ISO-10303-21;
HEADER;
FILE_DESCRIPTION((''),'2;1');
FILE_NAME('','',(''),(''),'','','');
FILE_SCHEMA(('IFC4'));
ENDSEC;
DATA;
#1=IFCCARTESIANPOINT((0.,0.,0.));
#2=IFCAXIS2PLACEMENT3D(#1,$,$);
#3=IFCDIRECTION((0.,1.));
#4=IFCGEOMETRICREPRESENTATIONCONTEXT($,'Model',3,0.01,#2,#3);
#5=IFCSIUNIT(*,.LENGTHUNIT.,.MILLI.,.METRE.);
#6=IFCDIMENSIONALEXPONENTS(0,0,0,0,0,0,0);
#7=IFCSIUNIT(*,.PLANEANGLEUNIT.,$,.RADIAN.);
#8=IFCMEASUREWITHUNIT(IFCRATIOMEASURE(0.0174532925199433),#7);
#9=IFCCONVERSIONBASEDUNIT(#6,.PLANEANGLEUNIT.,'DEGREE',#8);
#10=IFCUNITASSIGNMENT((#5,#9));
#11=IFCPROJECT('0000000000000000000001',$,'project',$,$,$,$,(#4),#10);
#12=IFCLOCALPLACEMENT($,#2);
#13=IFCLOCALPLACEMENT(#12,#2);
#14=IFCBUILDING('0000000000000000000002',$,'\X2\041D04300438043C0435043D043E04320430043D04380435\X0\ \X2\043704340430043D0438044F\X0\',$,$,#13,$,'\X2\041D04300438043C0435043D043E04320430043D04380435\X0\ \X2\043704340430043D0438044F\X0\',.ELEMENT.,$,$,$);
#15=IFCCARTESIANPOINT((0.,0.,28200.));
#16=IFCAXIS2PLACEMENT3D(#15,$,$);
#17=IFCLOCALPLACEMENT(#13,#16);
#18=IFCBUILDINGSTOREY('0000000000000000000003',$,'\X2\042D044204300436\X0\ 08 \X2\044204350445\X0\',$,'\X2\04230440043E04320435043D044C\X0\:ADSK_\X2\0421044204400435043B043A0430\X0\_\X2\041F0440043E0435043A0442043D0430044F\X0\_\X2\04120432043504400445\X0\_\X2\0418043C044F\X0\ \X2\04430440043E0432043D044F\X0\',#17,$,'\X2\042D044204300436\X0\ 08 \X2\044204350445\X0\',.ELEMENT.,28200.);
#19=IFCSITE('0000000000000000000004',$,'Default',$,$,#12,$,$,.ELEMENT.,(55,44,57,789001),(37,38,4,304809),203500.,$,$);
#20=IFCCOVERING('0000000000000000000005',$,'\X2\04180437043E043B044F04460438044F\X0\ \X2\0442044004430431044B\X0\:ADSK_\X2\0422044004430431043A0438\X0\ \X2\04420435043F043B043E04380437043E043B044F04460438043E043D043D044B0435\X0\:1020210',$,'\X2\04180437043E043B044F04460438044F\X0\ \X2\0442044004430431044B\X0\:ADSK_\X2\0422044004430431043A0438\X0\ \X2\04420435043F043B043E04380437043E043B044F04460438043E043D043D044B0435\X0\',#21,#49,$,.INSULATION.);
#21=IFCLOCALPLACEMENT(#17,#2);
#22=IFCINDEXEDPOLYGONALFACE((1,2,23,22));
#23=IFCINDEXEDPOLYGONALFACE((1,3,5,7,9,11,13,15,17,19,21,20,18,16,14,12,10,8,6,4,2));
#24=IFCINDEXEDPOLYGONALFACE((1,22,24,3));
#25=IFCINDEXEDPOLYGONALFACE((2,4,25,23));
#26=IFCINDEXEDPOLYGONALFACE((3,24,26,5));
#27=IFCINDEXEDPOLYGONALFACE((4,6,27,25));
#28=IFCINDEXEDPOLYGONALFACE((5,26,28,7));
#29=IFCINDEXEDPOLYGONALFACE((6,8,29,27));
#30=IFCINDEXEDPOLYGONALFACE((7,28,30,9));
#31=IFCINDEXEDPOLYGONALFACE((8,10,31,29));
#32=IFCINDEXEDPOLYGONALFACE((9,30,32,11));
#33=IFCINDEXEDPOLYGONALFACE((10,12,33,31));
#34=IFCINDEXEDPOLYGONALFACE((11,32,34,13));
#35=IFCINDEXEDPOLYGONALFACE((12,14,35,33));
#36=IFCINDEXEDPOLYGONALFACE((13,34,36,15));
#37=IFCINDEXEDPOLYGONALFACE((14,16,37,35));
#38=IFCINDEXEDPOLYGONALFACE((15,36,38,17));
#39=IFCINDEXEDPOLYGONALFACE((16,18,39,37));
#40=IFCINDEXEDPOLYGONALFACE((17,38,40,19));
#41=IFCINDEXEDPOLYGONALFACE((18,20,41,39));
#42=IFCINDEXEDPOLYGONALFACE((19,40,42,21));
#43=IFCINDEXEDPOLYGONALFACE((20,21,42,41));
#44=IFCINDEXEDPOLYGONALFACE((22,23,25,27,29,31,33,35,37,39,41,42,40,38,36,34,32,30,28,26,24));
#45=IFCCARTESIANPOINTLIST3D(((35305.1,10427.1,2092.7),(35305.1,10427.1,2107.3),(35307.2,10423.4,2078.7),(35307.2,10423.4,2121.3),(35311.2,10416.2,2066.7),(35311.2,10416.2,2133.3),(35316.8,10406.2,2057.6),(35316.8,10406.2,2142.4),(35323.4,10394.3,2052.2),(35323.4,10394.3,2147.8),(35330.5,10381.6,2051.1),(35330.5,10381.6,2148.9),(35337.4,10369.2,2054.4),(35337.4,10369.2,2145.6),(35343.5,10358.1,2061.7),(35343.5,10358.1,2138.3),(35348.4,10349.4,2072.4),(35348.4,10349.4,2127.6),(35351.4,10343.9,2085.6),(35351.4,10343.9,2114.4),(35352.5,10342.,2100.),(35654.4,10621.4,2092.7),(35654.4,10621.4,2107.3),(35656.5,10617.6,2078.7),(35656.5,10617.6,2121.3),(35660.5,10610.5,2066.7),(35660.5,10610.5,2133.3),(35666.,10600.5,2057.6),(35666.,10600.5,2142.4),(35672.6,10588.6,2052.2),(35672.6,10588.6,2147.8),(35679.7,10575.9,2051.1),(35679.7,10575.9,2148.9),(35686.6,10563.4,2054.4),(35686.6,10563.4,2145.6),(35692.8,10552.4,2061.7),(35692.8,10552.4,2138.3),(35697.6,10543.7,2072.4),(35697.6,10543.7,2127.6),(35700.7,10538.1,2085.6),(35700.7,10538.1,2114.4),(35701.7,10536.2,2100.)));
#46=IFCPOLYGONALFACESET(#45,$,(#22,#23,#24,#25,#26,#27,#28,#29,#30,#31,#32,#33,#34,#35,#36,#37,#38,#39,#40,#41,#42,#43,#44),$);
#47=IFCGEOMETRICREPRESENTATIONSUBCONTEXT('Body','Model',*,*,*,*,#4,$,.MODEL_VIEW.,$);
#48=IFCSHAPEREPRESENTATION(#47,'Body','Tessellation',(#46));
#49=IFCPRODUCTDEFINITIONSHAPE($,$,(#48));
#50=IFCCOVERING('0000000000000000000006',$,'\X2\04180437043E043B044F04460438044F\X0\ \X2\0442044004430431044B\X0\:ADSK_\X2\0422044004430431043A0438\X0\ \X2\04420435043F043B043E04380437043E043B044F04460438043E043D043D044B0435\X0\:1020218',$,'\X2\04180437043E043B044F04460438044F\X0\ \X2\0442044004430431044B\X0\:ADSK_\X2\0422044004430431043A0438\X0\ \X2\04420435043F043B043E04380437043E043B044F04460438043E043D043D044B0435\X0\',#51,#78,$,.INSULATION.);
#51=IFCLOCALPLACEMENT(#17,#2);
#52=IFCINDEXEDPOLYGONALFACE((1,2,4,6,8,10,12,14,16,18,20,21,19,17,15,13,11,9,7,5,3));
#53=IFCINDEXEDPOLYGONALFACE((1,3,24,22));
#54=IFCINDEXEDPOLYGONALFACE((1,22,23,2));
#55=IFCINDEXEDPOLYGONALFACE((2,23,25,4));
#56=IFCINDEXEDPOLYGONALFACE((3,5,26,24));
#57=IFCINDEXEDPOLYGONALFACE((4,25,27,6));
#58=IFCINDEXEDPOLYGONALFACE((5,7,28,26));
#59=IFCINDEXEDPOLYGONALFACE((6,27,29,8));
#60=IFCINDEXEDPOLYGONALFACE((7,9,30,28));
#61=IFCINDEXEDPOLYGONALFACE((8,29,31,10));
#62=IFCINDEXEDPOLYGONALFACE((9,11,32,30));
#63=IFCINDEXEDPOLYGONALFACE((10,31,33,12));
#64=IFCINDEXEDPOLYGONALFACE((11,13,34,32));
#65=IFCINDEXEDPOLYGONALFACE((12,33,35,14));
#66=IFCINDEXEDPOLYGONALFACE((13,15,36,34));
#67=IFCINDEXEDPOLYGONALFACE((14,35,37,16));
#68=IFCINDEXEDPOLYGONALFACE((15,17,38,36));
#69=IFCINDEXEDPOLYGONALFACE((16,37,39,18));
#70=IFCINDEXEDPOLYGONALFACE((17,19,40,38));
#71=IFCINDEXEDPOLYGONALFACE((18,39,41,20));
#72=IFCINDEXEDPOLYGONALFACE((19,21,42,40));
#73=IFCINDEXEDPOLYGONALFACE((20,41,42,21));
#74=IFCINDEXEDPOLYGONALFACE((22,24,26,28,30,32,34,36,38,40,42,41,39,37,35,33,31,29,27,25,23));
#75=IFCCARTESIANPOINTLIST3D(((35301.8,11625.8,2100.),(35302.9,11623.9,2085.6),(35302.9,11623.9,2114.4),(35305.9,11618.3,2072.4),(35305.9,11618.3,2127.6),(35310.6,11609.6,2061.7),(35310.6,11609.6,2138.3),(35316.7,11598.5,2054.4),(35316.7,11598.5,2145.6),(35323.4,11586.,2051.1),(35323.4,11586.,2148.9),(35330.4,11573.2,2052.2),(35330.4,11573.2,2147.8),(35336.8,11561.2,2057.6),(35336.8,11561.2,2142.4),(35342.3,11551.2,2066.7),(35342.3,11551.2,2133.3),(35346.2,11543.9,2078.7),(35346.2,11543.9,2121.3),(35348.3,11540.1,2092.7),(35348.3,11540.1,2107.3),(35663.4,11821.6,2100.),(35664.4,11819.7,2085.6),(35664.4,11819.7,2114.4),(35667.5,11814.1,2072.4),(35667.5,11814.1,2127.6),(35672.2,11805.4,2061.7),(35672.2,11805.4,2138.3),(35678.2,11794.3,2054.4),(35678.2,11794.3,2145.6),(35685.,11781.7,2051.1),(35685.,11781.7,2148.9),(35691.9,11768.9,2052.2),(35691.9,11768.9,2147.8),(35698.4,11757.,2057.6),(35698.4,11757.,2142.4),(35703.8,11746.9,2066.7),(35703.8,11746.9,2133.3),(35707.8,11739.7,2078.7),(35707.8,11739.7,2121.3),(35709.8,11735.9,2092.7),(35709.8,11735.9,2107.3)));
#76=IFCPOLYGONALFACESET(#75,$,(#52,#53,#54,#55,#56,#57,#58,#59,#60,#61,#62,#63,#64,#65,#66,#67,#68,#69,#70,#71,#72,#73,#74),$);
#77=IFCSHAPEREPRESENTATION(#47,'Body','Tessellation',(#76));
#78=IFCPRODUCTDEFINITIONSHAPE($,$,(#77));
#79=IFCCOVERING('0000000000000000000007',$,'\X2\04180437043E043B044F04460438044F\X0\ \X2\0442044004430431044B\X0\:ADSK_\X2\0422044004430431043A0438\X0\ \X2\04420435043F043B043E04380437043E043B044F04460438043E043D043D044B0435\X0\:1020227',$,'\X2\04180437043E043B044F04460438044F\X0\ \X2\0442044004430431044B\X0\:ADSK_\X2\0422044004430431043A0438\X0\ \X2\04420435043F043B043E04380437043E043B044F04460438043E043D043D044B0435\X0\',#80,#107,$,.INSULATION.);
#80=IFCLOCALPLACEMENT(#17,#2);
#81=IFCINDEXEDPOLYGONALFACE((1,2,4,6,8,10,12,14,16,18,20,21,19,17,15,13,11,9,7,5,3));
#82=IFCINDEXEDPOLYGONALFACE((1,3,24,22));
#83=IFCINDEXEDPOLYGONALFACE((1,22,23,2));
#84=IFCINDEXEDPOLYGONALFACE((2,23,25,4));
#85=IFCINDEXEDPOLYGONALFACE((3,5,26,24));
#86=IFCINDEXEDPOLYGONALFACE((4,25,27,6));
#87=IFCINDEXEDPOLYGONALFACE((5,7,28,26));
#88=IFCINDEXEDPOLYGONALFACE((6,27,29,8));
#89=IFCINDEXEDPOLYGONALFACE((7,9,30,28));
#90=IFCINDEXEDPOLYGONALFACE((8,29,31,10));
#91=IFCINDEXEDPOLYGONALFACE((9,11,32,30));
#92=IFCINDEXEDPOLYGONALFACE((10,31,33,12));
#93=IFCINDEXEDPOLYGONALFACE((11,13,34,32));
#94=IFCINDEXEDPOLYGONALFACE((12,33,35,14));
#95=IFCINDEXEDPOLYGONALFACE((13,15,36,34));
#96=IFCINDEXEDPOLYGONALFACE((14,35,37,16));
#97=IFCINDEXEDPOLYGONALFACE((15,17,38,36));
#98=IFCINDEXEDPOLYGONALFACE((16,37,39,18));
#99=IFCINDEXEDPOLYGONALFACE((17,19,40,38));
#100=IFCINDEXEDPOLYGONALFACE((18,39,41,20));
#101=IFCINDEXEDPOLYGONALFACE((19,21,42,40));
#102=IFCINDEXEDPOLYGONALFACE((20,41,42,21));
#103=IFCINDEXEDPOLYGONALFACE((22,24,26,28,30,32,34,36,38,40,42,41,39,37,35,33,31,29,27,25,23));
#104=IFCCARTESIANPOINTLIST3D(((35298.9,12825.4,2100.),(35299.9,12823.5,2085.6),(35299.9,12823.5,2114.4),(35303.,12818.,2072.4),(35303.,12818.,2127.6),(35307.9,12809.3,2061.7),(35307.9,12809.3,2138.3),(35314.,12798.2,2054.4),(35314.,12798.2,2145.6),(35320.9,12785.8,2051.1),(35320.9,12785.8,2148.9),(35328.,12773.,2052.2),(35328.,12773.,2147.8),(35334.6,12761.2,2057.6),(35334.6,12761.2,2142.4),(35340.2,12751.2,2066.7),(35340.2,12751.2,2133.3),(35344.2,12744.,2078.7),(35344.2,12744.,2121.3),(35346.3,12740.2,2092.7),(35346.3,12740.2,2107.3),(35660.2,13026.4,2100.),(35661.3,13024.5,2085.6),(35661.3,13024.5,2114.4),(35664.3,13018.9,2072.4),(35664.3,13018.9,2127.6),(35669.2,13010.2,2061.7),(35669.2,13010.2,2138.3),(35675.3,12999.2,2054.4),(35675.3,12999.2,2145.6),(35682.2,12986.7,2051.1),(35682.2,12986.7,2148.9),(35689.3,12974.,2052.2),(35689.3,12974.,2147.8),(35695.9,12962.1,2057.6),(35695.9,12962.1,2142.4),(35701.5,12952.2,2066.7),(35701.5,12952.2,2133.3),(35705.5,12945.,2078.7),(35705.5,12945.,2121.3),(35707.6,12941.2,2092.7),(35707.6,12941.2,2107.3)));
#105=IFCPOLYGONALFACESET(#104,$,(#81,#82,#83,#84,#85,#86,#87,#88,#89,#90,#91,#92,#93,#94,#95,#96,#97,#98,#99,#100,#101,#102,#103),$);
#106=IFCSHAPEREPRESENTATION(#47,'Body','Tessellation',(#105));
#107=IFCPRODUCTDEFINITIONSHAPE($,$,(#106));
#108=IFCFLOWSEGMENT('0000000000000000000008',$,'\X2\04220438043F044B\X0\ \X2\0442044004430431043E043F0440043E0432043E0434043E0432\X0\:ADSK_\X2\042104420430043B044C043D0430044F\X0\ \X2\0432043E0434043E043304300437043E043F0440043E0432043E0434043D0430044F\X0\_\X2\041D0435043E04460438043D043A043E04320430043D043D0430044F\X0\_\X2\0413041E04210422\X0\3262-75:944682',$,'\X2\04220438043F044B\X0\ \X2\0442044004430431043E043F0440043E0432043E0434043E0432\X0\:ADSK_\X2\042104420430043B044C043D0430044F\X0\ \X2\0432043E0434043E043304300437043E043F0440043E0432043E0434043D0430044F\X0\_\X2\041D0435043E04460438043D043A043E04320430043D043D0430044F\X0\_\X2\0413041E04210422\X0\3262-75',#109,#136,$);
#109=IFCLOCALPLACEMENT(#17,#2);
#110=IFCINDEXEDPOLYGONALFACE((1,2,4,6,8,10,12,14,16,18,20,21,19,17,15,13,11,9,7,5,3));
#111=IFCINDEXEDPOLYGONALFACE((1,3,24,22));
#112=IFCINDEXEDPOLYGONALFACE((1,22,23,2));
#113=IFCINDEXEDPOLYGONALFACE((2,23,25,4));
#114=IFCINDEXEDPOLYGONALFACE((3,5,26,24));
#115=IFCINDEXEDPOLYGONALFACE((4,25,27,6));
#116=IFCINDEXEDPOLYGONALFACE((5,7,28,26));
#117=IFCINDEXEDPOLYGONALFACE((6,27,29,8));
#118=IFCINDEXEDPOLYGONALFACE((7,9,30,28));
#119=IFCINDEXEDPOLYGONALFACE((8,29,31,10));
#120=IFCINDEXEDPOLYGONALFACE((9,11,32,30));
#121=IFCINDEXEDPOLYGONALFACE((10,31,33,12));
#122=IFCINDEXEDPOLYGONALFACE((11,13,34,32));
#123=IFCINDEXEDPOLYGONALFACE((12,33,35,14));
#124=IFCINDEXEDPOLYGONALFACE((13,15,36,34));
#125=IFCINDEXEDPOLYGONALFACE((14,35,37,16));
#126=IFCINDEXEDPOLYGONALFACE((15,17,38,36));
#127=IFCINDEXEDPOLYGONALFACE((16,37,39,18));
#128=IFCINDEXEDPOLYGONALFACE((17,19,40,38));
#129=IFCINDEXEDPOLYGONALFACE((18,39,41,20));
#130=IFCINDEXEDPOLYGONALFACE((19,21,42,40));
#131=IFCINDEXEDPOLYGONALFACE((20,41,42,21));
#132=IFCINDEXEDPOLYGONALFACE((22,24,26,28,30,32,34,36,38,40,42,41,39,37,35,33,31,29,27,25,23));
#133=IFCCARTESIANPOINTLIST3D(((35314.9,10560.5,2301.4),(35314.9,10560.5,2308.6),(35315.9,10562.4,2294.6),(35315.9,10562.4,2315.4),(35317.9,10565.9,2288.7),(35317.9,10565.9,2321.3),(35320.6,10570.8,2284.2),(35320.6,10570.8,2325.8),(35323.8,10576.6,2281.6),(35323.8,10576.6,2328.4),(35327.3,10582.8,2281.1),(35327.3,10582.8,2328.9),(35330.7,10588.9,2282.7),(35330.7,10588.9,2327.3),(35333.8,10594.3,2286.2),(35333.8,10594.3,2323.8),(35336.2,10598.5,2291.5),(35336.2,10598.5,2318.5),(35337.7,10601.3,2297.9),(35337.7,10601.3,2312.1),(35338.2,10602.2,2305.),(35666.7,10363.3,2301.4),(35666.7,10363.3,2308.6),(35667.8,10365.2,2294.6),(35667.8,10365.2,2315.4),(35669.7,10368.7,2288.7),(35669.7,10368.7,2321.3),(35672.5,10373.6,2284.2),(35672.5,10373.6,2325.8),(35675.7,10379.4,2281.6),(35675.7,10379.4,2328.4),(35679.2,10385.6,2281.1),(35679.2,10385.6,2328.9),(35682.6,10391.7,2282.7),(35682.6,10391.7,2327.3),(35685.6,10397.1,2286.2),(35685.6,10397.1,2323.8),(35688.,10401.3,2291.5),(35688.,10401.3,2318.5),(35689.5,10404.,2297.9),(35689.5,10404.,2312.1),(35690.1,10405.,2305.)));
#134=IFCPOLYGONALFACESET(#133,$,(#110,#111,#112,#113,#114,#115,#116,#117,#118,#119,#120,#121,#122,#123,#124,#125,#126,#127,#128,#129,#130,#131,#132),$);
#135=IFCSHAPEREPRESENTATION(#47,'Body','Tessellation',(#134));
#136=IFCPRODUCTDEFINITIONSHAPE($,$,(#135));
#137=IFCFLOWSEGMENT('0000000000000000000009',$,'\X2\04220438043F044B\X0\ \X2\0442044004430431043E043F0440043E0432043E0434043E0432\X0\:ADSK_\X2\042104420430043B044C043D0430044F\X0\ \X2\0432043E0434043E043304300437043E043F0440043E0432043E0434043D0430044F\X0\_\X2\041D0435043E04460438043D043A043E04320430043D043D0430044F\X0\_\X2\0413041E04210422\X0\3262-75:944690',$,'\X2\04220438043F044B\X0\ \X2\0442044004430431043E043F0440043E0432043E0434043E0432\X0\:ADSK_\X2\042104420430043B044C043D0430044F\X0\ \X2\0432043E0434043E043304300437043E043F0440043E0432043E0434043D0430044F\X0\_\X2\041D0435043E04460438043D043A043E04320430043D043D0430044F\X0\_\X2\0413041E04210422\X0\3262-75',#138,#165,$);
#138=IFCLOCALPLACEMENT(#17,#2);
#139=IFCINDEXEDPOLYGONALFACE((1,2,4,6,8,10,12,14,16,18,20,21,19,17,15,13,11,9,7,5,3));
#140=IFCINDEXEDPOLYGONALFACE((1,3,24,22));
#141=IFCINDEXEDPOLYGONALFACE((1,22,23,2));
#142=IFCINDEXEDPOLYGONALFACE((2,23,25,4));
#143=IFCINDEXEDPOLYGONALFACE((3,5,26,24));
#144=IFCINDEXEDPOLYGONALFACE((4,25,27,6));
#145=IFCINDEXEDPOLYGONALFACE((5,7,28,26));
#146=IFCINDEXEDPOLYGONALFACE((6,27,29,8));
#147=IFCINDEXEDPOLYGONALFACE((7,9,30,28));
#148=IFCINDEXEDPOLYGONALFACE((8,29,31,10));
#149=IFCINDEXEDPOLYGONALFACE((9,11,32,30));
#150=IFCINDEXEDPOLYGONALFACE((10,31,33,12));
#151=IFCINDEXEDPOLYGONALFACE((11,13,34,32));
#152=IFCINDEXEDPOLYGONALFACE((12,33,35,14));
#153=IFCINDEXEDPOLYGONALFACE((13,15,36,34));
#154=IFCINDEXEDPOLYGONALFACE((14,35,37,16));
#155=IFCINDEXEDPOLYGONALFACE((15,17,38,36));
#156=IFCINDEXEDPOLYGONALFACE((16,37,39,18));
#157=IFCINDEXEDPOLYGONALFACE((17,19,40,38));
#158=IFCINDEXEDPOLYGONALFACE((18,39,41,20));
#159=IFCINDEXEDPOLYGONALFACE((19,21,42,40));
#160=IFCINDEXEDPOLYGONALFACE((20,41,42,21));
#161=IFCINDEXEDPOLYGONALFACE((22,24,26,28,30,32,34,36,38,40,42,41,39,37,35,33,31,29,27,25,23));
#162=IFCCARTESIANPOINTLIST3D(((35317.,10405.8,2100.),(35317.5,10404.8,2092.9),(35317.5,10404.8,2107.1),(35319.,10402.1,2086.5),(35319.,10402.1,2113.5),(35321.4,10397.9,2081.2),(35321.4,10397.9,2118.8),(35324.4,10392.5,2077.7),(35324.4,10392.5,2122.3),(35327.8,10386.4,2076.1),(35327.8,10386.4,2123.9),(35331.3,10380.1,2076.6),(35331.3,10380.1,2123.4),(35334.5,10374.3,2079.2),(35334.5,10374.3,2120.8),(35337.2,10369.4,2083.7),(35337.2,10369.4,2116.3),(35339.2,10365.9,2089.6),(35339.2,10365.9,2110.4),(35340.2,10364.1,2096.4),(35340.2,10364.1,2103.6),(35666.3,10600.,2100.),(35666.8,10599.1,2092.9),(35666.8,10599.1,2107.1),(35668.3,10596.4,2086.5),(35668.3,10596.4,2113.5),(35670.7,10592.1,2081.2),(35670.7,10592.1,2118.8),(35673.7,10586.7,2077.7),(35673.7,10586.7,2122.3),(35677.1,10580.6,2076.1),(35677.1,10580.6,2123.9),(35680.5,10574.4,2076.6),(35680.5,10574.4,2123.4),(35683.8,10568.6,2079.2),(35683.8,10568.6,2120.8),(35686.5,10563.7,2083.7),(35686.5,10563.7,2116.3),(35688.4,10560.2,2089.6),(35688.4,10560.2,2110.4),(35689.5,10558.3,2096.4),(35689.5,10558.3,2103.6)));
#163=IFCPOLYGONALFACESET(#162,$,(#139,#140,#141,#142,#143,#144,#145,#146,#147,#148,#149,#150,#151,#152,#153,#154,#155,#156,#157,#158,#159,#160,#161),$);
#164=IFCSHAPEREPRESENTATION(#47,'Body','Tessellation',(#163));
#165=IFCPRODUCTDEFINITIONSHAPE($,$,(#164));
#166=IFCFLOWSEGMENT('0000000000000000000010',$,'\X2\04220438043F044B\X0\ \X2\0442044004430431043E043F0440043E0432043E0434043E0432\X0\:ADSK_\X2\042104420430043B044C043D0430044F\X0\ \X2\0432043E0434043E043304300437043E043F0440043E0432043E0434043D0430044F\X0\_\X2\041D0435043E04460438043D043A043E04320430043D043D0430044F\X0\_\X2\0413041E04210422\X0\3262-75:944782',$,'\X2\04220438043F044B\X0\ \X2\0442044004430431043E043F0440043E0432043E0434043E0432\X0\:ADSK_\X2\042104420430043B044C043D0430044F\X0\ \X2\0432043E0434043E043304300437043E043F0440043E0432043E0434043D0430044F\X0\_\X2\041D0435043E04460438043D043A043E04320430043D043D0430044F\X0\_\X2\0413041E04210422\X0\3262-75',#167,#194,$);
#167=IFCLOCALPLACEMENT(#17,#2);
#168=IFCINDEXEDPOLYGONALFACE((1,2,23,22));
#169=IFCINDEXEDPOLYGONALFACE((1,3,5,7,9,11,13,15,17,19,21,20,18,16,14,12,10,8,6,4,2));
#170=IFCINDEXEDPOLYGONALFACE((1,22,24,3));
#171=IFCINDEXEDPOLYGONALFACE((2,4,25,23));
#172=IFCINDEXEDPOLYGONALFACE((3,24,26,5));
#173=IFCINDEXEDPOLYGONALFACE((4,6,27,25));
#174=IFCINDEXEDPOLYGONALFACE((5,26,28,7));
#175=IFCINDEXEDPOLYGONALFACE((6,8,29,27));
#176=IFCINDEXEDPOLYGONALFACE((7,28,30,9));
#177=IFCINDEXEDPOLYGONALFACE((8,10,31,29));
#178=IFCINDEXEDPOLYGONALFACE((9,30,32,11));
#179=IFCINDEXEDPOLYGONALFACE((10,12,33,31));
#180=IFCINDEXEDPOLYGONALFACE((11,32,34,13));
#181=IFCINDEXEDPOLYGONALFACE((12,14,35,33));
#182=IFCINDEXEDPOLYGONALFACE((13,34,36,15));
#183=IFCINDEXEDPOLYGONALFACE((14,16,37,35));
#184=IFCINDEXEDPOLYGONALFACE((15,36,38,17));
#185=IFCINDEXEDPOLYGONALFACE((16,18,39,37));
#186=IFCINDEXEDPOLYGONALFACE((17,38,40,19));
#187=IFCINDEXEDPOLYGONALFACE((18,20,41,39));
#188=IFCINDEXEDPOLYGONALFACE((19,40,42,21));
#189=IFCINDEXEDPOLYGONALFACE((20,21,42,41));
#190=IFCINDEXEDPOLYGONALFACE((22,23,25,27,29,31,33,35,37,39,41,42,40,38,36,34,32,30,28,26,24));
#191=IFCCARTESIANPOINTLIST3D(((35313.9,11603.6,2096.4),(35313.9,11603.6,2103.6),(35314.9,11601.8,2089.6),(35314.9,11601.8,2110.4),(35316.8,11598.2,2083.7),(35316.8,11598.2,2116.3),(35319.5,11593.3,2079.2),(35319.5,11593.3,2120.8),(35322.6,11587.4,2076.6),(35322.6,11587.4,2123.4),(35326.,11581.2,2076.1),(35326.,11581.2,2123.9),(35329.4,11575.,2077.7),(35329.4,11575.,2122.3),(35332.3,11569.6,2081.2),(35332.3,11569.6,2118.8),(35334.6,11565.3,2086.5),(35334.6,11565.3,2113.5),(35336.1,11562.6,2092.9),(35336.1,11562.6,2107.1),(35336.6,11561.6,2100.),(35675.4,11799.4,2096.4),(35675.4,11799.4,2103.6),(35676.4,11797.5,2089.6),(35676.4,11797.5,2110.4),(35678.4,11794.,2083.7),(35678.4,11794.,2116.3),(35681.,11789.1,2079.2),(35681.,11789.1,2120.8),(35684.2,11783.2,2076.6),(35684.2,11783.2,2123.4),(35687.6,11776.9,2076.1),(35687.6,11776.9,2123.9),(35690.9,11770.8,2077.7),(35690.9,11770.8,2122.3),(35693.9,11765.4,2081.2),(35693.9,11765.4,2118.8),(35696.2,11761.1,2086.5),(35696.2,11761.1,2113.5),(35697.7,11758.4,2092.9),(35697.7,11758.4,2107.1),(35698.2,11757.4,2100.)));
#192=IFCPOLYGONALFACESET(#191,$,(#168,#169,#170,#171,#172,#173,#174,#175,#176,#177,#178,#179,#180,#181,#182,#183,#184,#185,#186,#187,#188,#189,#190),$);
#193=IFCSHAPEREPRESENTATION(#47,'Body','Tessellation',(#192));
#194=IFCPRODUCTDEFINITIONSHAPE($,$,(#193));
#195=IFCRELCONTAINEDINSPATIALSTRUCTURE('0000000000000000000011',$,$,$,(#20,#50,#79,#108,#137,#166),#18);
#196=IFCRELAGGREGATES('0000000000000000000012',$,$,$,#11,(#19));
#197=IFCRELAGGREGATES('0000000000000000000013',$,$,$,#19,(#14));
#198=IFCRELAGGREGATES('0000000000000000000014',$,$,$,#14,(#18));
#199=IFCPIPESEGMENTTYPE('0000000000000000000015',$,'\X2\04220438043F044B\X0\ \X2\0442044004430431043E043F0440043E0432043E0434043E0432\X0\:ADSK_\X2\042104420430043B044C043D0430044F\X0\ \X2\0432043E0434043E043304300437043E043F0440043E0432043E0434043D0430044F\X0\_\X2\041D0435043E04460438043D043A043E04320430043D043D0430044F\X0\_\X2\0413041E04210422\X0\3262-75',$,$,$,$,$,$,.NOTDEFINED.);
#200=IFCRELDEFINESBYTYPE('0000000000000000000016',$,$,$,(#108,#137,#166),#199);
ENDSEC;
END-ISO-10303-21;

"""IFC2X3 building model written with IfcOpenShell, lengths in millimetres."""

from ifc_helpers import new_model, entity, si_unit, converted_unit, direction, frame, origin, origin_2d_with_axis, place, context, subcontext, project, spatial, circle, extrude, type_object, element, save


model = new_model("IFC2X3")

# Units and contexts
model_context = context("Model", 3, precision=0.01, world=origin(), true_north=direction((0.0, 1.0)))
body_context = subcontext(model_context, "Body", "Model", "MODEL_VIEW")
ifc_project = project(units=[si_unit("LENGTHUNIT", "METRE", prefix="MILLI"), converted_unit("PLANEANGLEUNIT", "DEGREE", entity("IfcRatioMeasure", 0.0174532925199433), si_unit("PLANEANGLEUNIT", "RADIAN"), dimensions=[0, 0, 0, 0, 0, 0, 0])], contexts=[model_context])

# Site, building, storey
site_placement = place(None, origin())
site = spatial("IfcSite", under=ifc_project, at=site_placement, Name="Default", CompositionType="ELEMENT", RefLatitude=(55, 44, 57, 789001), RefLongitude=(37, 38, 4, 304809), RefElevation=203500.0)
building_placement = place(site_placement, origin())
building = spatial("IfcBuilding", under=site, at=building_placement, Name="Наименование здания", LongName="Наименование здания", CompositionType="ELEMENT")
storey_placement = place(building_placement, frame((0.0, 0.0, 28200.0)))
storey = spatial("IfcBuildingStorey", under=building, at=storey_placement, Name="Этаж 08 тех", ObjectType="Уровень:ADSK_Стрелка_Проектная_Вверх_Имя уровня", LongName="Этаж 08 тех", CompositionType="ELEMENT", Elevation=28200.0)

# Coverings
covering_1_placement = place(storey_placement, frame((35303.3, 10340.4, 2049.4)))
element("IfcCovering", 1, at=covering_1_placement, inside=storey, Name="Изоляция трубы:ADSK_Трубки теплоизоляционные:1020210", ObjectType="Изоляция трубы:ADSK_Трубки теплоизоляционные", PredefinedType="INSULATION", context=body_context, shape_type="SweptSolid", body=[
    extrude(circle(Radius=49.0, at=origin_2d_with_axis()), frame((25.4, 44.4, 50.6), z_axis=(0.873901, 0.486104, 0.0), x_axis=(0.486104, -0.873901, 0.0)), (0.0, 0.0, 1.0), 399.6),
])
covering_2_placement = place(storey_placement, frame((35300.2, 11538.1, 2049.4)))
element("IfcCovering", 2, at=covering_2_placement, inside=storey, Name="Изоляция трубы:ADSK_Трубки теплоизоляционные:1020218", ObjectType="Изоляция трубы:ADSK_Трубки теплоизоляционные", PredefinedType="INSULATION", context=body_context, shape_type="SweptSolid", body=[
    extrude(circle(Radius=49.0, at=origin_2d_with_axis()), frame((24.9, 44.7, 50.6), z_axis=(0.87935, 0.476176, 0.0), x_axis=(-0.476176, 0.87935, 0.0)), (0.0, 0.0, 1.0), 411.2),
])
covering_3_placement = place(storey_placement, frame((35297.3, 12738.1, 2049.4)))
element("IfcCovering", 3, at=covering_3_placement, inside=storey, Name="Изоляция трубы:ADSK_Трубки теплоизоляционные:1020227", ObjectType="Изоляция трубы:ADSK_Трубки теплоизоляционные", PredefinedType="INSULATION", context=body_context, shape_type="SweptSolid", body=[
    extrude(circle(Radius=49.0, at=origin_2d_with_axis()), frame((25.4, 44.4, 50.6), z_axis=(0.873901, 0.486104, 0.0), x_axis=(-0.486104, 0.873901, 0.0)), (0.0, 0.0, 1.0), 413.4),
])

# Flow segments
pipe_segment_type = type_object("IfcPipeSegmentType", Name="Типы трубопроводов:ADSK_Стальная водогазопроводная_Неоцинкованная_ГОСТ3262-75", PredefinedType="NOTDEFINED")
flow_segment_1_placement = place(storey_placement, frame((35313.1, 10361.5, 2279.4)))
element("IfcFlowSegment", 4, at=flow_segment_1_placement, inside=storey, type_object=pipe_segment_type, Name="Типы трубопроводов:ADSK_Стальная водогазопроводная_Неоцинкованная_ГОСТ3262-75:944682", ObjectType="Типы трубопроводов:ADSK_Стальная водогазопроводная_Неоцинкованная_ГОСТ3262-75", context=body_context, shape_type="SweptSolid", body=[
    extrude(circle(Radius=24.0, at=origin_2d_with_axis()), frame((13.3, 219.7, 25.6), z_axis=(0.872329, -0.48892, 0.0), x_axis=(0.48892, 0.872329, 0.0)), (0.0, 0.0, 1.0), 403.4),
])
flow_segment_2_placement = place(storey_placement, frame((35315.4, 10362.2, 2074.4)))
element("IfcFlowSegment", 5, at=flow_segment_2_placement, inside=storey, type_object=pipe_segment_type, Name="Типы трубопроводов:ADSK_Стальная водогазопроводная_Неоцинкованная_ГОСТ3262-75:944690", ObjectType="Типы трубопроводов:ADSK_Стальная водогазопроводная_Неоцинкованная_ГОСТ3262-75", context=body_context, shape_type="SweptSolid", body=[
    extrude(circle(Radius=24.0, at=origin_2d_with_axis()), frame((13.3, 22.6, 25.6), z_axis=(0.873901, 0.486104, 0.0), x_axis=(-0.486104, 0.873901, 0.0)), (0.0, 0.0, 1.0), 399.6),
])
flow_segment_3_placement = place(storey_placement, frame((35312.2, 11560.0, 2074.4)))
element("IfcFlowSegment", 6, at=flow_segment_3_placement, inside=storey, type_object=pipe_segment_type, Name="Типы трубопроводов:ADSK_Стальная водогазопроводная_Неоцинкованная_ГОСТ3262-75:944782", ObjectType="Типы трубопроводов:ADSK_Стальная водогазопроводная_Неоцинкованная_ГОСТ3262-75", context=body_context, shape_type="SweptSolid", body=[
    extrude(circle(Radius=24.0, at=origin_2d_with_axis()), frame((13.0, 22.7, 25.6), z_axis=(0.87935, 0.476176, 0.0), x_axis=(0.476176, -0.87935, 0.0)), (0.0, 0.0, 1.0), 411.2),
])

save(model, "model.ifc")
